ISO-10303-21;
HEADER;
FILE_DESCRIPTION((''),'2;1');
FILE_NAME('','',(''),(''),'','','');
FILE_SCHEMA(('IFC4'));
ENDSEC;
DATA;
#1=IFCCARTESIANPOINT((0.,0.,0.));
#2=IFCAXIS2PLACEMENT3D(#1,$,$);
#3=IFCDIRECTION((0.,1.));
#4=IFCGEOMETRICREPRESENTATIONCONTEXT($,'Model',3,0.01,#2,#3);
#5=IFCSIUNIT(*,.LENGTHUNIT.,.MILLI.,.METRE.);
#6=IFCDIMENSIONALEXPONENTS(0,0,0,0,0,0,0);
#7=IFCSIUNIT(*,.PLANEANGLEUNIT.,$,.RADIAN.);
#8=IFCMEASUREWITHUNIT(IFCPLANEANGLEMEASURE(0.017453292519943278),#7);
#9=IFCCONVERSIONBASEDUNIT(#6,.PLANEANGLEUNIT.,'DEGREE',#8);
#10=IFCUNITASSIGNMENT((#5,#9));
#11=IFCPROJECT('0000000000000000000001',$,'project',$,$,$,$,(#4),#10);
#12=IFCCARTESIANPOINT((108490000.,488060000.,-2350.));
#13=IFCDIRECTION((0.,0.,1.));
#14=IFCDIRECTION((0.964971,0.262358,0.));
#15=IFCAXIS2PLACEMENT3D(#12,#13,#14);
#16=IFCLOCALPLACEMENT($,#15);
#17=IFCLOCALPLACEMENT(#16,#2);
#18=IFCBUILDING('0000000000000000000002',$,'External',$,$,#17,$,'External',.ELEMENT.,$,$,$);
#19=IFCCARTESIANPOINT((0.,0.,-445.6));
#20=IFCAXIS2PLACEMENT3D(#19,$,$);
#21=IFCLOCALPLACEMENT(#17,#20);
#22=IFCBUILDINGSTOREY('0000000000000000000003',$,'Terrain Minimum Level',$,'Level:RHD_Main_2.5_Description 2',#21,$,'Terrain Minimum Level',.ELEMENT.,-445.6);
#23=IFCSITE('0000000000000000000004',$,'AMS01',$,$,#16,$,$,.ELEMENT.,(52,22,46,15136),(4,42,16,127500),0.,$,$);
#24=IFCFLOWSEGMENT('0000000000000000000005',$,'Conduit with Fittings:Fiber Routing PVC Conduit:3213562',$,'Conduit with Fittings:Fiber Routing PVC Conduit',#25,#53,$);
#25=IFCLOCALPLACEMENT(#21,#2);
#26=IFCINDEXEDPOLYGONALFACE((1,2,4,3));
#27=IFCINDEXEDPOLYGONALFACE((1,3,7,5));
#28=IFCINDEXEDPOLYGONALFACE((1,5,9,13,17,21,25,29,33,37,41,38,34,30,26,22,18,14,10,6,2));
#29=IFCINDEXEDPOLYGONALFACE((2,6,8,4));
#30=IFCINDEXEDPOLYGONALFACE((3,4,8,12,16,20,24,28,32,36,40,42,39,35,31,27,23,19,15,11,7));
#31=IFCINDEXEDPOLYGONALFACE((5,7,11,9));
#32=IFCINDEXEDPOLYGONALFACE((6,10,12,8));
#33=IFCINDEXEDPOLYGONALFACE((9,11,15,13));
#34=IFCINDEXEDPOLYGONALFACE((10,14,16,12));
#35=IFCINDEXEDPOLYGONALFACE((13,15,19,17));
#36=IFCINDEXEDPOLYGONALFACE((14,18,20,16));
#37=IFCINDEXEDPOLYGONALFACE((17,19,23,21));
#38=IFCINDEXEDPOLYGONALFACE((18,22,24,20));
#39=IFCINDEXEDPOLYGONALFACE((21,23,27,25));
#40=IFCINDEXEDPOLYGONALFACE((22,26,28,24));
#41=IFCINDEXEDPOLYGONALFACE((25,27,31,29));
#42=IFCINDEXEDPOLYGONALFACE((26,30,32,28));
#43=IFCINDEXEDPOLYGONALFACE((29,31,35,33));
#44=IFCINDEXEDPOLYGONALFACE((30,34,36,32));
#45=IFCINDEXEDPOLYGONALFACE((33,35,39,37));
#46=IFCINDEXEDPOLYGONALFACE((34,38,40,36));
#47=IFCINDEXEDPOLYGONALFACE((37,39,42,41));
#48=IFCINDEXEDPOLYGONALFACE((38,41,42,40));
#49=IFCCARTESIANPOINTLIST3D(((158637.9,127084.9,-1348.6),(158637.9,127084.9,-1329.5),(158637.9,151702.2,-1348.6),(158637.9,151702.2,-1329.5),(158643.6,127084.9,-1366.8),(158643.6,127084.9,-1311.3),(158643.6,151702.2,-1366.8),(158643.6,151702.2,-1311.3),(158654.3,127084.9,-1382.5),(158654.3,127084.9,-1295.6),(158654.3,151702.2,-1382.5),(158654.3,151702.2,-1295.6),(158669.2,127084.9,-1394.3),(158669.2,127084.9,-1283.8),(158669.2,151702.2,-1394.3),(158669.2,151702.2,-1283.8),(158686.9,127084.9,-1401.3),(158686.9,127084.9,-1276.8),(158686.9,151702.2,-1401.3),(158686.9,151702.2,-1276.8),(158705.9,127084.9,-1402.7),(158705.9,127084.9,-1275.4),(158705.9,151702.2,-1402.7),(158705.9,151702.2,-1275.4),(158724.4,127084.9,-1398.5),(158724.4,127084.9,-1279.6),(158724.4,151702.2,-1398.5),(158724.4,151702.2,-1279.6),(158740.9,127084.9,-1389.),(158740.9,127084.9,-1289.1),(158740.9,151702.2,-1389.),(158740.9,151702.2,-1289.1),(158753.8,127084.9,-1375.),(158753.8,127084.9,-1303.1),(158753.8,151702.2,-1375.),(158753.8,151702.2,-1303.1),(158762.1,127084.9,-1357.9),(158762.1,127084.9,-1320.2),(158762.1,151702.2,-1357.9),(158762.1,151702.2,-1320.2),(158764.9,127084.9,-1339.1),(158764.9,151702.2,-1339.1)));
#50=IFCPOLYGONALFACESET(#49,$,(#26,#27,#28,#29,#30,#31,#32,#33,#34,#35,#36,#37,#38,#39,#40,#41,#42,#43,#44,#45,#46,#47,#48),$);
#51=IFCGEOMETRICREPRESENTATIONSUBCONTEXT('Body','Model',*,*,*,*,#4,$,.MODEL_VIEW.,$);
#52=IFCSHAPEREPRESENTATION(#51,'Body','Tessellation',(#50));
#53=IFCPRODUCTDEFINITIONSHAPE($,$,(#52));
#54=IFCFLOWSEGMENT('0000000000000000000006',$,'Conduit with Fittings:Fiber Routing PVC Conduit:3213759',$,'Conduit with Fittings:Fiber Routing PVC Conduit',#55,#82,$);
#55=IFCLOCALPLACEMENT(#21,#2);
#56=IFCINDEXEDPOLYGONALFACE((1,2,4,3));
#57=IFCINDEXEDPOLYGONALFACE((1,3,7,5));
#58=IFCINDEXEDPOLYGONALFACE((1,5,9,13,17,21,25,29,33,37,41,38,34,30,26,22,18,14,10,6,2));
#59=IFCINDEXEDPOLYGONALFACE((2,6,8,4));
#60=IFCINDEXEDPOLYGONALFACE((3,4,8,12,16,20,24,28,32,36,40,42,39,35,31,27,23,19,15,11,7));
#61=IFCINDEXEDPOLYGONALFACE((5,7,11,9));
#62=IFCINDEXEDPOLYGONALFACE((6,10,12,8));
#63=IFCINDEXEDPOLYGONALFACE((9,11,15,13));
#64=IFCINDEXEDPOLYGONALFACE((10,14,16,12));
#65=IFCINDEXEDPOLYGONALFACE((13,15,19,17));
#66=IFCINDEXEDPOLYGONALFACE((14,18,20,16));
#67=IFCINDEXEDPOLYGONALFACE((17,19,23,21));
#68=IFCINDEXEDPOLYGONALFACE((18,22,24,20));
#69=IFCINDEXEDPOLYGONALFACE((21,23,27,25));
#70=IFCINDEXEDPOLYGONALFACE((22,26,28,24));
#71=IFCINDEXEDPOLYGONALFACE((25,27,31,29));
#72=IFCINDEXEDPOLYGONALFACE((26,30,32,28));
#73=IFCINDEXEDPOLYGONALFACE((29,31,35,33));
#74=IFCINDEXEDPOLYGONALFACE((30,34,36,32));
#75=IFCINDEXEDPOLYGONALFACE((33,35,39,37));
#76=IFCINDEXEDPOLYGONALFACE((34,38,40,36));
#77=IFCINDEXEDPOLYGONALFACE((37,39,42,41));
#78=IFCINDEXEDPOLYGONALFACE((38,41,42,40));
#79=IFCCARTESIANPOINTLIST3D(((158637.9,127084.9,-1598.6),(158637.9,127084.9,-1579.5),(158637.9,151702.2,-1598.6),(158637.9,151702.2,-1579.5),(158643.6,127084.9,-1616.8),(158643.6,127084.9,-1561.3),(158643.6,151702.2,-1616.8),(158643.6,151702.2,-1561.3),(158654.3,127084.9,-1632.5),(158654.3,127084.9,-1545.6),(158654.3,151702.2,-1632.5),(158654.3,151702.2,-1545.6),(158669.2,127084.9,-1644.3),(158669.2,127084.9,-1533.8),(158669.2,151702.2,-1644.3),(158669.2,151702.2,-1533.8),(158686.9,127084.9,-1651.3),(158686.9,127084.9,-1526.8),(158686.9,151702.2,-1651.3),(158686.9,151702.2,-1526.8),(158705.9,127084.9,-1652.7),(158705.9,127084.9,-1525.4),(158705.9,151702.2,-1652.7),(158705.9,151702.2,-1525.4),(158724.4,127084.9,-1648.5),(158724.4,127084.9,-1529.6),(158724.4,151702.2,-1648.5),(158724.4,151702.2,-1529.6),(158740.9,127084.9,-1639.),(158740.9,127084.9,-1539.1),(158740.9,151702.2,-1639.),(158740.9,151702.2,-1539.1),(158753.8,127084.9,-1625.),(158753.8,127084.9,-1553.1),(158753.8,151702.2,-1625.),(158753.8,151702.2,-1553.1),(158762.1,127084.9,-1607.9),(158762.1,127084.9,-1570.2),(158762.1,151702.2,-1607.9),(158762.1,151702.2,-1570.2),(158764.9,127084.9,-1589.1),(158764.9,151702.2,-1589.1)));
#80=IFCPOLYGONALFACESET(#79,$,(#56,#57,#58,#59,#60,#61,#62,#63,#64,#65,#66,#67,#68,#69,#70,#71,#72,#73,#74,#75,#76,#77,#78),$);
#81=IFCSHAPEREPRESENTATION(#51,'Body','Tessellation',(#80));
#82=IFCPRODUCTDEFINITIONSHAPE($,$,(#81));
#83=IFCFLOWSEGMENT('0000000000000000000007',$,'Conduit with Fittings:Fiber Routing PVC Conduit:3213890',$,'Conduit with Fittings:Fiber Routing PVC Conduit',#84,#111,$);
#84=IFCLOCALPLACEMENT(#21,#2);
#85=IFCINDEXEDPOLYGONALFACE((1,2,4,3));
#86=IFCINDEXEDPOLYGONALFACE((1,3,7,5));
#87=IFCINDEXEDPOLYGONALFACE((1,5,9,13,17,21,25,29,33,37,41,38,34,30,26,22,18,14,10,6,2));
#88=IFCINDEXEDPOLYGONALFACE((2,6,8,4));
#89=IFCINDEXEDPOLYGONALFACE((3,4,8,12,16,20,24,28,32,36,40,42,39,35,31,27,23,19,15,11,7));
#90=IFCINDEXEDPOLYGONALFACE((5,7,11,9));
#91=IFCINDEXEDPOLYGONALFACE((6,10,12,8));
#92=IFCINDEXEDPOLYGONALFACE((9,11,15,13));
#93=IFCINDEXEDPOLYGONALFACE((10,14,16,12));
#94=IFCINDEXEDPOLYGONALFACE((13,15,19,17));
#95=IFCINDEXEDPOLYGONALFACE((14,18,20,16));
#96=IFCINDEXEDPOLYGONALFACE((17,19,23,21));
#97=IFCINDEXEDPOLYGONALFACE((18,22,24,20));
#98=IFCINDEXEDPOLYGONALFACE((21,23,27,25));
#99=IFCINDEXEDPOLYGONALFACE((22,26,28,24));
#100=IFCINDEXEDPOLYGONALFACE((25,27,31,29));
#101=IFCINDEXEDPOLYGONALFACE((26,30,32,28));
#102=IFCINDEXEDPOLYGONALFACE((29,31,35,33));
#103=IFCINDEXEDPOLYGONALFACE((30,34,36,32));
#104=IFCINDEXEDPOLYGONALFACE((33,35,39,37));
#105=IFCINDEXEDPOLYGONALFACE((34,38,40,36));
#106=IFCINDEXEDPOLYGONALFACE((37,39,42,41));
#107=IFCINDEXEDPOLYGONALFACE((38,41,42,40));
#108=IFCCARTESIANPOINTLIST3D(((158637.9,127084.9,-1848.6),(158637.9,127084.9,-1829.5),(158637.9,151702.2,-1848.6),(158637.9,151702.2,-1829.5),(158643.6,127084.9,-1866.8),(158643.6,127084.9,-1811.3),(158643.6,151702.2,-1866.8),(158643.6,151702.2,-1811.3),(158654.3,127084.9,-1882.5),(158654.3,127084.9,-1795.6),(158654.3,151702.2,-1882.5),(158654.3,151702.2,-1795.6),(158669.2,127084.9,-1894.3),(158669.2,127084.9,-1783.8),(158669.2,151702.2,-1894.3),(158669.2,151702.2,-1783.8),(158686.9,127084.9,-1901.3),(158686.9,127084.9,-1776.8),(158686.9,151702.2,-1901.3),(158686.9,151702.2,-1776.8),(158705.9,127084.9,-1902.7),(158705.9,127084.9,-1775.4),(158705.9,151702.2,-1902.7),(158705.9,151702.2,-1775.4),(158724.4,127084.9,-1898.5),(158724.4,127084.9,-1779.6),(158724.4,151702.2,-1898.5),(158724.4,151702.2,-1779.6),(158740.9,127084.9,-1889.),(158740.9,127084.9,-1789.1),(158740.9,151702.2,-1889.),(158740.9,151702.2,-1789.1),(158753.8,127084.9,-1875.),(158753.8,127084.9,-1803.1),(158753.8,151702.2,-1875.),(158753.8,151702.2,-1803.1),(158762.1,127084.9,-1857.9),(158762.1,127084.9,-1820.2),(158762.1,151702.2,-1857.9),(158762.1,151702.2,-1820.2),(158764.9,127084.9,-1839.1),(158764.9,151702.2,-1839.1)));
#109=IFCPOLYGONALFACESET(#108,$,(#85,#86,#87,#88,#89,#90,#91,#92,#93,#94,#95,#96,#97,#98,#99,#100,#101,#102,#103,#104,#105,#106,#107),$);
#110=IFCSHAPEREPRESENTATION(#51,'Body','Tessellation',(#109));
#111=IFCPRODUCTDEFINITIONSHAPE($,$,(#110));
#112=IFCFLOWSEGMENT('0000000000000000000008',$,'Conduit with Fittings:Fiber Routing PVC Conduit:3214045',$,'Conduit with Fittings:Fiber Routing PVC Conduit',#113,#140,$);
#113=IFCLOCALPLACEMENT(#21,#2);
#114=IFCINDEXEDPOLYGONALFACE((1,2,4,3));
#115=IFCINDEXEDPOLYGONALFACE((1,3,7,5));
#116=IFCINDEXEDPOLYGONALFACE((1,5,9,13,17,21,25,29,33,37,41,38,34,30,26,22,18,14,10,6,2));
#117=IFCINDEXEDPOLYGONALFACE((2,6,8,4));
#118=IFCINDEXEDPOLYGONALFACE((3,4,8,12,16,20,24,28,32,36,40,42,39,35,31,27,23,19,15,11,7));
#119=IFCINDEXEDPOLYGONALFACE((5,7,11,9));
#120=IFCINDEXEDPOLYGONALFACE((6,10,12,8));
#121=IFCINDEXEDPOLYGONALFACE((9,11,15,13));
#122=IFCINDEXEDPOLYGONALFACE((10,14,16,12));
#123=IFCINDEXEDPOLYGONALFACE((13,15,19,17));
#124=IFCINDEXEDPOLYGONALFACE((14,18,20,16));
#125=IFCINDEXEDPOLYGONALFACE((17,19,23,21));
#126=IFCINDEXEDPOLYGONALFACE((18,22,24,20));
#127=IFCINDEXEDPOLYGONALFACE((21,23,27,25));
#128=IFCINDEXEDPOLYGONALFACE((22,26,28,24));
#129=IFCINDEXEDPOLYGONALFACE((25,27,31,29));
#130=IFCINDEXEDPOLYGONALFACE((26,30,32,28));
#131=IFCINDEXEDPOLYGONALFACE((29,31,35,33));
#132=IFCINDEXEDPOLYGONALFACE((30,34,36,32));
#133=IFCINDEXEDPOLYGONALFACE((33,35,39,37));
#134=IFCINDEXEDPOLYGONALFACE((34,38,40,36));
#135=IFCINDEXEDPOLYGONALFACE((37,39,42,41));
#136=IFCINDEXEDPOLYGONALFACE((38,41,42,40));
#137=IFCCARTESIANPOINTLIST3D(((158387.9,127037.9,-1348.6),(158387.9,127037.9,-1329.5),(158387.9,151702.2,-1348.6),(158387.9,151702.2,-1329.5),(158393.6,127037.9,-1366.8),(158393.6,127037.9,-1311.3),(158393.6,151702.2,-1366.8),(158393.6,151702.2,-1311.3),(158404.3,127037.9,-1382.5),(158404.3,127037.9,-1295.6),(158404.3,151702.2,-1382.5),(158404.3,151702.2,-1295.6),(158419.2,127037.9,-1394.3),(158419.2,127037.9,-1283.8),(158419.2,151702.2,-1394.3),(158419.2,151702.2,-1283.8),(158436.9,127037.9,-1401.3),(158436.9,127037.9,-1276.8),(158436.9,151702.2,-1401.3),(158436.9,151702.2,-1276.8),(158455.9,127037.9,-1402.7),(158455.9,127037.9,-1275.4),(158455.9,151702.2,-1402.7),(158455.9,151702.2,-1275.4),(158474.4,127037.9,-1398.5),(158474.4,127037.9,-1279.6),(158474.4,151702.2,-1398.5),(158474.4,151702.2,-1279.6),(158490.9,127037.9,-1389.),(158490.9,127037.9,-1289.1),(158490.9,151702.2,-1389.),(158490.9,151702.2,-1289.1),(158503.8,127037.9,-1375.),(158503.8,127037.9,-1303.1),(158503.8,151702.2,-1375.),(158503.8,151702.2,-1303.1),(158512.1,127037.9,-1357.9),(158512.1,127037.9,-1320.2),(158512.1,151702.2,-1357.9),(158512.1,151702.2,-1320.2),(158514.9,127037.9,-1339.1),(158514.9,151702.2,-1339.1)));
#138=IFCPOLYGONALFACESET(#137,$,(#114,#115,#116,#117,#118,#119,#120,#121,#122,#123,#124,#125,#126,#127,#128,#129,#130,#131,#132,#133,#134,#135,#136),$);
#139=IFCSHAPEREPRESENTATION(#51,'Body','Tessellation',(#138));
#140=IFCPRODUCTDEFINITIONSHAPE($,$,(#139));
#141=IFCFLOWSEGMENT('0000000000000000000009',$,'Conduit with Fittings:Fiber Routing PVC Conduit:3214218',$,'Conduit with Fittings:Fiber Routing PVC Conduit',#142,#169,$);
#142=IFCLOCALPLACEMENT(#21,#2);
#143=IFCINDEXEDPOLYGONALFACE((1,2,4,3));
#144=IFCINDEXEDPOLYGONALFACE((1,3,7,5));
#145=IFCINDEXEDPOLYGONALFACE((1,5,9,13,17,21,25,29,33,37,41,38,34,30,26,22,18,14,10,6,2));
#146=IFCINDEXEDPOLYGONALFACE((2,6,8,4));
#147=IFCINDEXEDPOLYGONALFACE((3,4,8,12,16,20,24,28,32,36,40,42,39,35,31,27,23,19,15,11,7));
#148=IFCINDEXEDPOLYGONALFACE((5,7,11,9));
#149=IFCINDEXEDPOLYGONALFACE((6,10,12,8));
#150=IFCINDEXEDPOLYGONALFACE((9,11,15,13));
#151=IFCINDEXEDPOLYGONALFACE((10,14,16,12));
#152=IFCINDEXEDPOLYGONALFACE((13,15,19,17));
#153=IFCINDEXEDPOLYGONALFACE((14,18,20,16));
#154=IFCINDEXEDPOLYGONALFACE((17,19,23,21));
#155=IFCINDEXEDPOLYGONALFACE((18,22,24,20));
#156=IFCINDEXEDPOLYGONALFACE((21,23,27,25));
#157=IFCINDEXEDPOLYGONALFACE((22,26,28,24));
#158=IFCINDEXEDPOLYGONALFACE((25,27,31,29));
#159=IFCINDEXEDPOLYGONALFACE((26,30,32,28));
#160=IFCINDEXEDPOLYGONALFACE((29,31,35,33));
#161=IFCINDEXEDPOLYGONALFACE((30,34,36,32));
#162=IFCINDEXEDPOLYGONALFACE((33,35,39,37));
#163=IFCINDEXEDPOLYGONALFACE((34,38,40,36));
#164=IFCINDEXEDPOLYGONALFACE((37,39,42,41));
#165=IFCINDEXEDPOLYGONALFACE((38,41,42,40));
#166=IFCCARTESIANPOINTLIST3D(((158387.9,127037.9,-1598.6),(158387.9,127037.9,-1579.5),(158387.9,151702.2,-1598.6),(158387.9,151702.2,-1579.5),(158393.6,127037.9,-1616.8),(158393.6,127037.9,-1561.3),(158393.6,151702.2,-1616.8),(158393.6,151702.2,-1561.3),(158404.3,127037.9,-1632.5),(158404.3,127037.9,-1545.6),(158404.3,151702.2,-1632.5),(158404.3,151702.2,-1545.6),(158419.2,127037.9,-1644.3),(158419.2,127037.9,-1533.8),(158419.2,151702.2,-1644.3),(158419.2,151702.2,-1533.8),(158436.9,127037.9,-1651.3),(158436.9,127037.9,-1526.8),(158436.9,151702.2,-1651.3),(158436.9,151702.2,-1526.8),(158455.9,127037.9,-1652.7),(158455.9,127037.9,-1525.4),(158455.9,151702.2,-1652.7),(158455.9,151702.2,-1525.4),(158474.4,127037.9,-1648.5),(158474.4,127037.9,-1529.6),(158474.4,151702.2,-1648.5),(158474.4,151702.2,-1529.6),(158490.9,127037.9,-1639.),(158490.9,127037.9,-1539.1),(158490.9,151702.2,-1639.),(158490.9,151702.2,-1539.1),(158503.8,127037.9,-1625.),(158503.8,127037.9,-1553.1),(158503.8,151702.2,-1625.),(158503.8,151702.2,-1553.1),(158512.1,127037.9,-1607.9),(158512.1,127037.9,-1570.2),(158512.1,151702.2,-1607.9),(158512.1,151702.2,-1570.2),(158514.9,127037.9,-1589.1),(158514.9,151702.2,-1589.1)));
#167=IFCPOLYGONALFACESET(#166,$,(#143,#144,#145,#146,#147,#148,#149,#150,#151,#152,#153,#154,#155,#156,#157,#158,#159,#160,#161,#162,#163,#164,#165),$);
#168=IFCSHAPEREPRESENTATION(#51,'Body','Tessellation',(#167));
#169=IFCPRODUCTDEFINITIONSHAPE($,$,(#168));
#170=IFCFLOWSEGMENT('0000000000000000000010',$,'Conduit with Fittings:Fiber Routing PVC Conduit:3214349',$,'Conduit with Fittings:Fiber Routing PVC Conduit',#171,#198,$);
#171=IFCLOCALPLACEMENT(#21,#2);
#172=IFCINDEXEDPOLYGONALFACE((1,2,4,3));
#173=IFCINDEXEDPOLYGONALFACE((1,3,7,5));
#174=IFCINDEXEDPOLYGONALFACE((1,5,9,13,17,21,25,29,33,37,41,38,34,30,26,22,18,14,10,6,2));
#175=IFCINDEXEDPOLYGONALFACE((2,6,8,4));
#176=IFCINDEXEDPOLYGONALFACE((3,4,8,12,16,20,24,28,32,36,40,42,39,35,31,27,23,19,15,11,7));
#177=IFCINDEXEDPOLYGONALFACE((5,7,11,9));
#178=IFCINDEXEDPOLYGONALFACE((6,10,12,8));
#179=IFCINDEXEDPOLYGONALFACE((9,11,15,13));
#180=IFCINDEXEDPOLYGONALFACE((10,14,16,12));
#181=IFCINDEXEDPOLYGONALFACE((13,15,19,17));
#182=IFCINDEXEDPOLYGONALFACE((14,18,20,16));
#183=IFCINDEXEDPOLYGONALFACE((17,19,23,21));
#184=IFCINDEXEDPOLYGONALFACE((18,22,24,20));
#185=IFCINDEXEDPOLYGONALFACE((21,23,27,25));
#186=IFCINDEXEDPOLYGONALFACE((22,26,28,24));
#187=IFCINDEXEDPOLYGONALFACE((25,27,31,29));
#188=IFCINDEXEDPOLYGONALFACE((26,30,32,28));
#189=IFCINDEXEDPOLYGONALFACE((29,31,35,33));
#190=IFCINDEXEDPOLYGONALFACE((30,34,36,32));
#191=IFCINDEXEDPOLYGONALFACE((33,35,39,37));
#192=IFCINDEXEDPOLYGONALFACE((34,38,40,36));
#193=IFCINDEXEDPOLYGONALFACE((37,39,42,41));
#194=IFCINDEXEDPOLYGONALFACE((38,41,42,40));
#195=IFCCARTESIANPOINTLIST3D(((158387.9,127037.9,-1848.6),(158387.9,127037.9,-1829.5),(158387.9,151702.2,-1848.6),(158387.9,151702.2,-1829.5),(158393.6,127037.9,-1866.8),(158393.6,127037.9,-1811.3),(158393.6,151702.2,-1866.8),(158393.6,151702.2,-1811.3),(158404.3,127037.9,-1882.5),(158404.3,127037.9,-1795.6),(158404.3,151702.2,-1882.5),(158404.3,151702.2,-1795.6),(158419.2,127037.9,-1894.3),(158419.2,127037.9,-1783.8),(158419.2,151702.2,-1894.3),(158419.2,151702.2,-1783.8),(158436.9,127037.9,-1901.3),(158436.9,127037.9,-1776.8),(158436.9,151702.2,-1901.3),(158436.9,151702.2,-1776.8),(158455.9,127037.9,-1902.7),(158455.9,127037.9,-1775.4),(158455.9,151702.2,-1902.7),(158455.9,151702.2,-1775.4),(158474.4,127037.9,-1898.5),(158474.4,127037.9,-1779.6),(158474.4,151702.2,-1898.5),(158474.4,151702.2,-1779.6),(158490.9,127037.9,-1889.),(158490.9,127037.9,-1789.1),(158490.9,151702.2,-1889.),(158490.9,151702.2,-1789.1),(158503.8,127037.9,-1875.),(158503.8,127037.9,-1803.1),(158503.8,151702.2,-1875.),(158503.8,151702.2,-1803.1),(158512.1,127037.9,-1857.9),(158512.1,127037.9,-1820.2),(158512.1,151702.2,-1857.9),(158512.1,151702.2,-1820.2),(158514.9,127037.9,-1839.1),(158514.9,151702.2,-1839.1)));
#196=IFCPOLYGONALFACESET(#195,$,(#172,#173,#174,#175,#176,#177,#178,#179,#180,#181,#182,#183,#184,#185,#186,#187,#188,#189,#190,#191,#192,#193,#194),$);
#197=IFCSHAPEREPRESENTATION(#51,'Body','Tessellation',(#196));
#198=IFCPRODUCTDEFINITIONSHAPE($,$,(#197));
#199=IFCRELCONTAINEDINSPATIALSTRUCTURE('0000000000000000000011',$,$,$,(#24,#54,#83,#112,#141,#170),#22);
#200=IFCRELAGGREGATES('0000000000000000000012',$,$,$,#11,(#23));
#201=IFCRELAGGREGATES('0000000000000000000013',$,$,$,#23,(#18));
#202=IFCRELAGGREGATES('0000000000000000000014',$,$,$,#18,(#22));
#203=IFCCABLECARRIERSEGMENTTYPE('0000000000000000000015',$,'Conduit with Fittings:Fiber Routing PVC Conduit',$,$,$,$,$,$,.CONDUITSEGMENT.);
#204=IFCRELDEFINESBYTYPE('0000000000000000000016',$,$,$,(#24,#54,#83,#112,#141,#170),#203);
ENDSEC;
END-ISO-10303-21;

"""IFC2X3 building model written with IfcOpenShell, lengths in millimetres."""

from ifc_helpers import new_model, entity, si_unit, converted_unit, direction, frame, origin, origin_2d_with_axis, place, context, subcontext, project, spatial, circle, extrude, type_object, element, save


model = new_model("IFC2X3")

# Units and contexts
model_context = context("Model", 3, precision=0.01, world=origin(), true_north=direction((0.0, 1.0)))
body_context = subcontext(model_context, "Body", "Model", "MODEL_VIEW")
ifc_project = project(units=[si_unit("LENGTHUNIT", "METRE", prefix="MILLI"), converted_unit("PLANEANGLEUNIT", "DEGREE", entity("IfcPlaneAngleMeasure", 0.017453292519943278), si_unit("PLANEANGLEUNIT", "RADIAN"), dimensions=[0, 0, 0, 0, 0, 0, 0])], contexts=[model_context])

# Site, building, storey
site_placement = place(None, frame((108490000.0, 488060000.0, -2350.0), z_axis=(0.0, 0.0, 1.0), x_axis=(0.964971, 0.262358, 0.0)))
site = spatial("IfcSite", under=ifc_project, at=site_placement, Name="AMS01", CompositionType="ELEMENT", RefLatitude=(52, 22, 46, 15136), RefLongitude=(4, 42, 16, 127500), RefElevation=0.0)
building_placement = place(site_placement, origin())
building = spatial("IfcBuilding", under=site, at=building_placement, Name="External", LongName="External", CompositionType="ELEMENT")
storey_placement = place(building_placement, frame((0.0, 0.0, -445.6)))
storey = spatial("IfcBuildingStorey", under=building, at=storey_placement, Name="Terrain Minimum Level", ObjectType="Level:RHD_Main_2.5_Description 2", LongName="Terrain Minimum Level", CompositionType="ELEMENT", Elevation=-445.6)

# Flow segments
cable_carrier_segment_type = type_object("IfcCableCarrierSegmentType", Name="Conduit with Fittings:Fiber Routing PVC Conduit", PredefinedType="CONDUITSEGMENT")
flow_segment_1_placement = place(storey_placement, origin())
element("IfcFlowSegment", 1, at=flow_segment_1_placement, inside=storey, type_object=cable_carrier_segment_type, Name="Conduit with Fittings:Fiber Routing PVC Conduit:3213562", ObjectType="Conduit with Fittings:Fiber Routing PVC Conduit", context=body_context, shape_type="SweptSolid", body=[
    extrude(circle(Radius=63.9, at=origin_2d_with_axis()), frame((158701.1, 127084.9, -1339.1), z_axis=(0.0, 1.0, 0.0), x_axis=(1.0, 0.0, 0.0)), (0.0, 0.0, 1.0), 24617.4),
])
flow_segment_2_placement = place(storey_placement, origin())
element("IfcFlowSegment", 2, at=flow_segment_2_placement, inside=storey, type_object=cable_carrier_segment_type, Name="Conduit with Fittings:Fiber Routing PVC Conduit:3213759", ObjectType="Conduit with Fittings:Fiber Routing PVC Conduit", context=body_context, shape_type="SweptSolid", body=[
    extrude(circle(Radius=63.9, at=origin_2d_with_axis()), frame((158701.1, 127084.9, -1589.1), z_axis=(0.0, 1.0, 0.0), x_axis=(1.0, 0.0, 0.0)), (0.0, 0.0, 1.0), 24617.4),
])
flow_segment_3_placement = place(storey_placement, origin())
element("IfcFlowSegment", 3, at=flow_segment_3_placement, inside=storey, type_object=cable_carrier_segment_type, Name="Conduit with Fittings:Fiber Routing PVC Conduit:3213890", ObjectType="Conduit with Fittings:Fiber Routing PVC Conduit", context=body_context, shape_type="SweptSolid", body=[
    extrude(circle(Radius=63.9, at=origin_2d_with_axis()), frame((158701.1, 127084.9, -1839.1), z_axis=(0.0, 1.0, 0.0), x_axis=(1.0, 0.0, 0.0)), (0.0, 0.0, 1.0), 24617.4),
])
flow_segment_4_placement = place(storey_placement, origin())
element("IfcFlowSegment", 4, at=flow_segment_4_placement, inside=storey, type_object=cable_carrier_segment_type, Name="Conduit with Fittings:Fiber Routing PVC Conduit:3214045", ObjectType="Conduit with Fittings:Fiber Routing PVC Conduit", context=body_context, shape_type="SweptSolid", body=[
    extrude(circle(Radius=63.9, at=origin_2d_with_axis()), frame((158451.1, 127037.9, -1339.1), z_axis=(0.0, 1.0, 0.0), x_axis=(1.0, 0.0, 0.0)), (0.0, 0.0, 1.0), 24664.4),
])
flow_segment_5_placement = place(storey_placement, origin())
element("IfcFlowSegment", 5, at=flow_segment_5_placement, inside=storey, type_object=cable_carrier_segment_type, Name="Conduit with Fittings:Fiber Routing PVC Conduit:3214218", ObjectType="Conduit with Fittings:Fiber Routing PVC Conduit", context=body_context, shape_type="SweptSolid", body=[
    extrude(circle(Radius=63.9, at=origin_2d_with_axis()), frame((158451.1, 127037.9, -1589.1), z_axis=(0.0, 1.0, 0.0), x_axis=(1.0, 0.0, 0.0)), (0.0, 0.0, 1.0), 24664.4),
])
flow_segment_6_placement = place(storey_placement, origin())
element("IfcFlowSegment", 6, at=flow_segment_6_placement, inside=storey, type_object=cable_carrier_segment_type, Name="Conduit with Fittings:Fiber Routing PVC Conduit:3214349", ObjectType="Conduit with Fittings:Fiber Routing PVC Conduit", context=body_context, shape_type="SweptSolid", body=[
    extrude(circle(Radius=63.9, at=origin_2d_with_axis()), frame((158451.1, 127037.9, -1839.1), z_axis=(0.0, 1.0, 0.0), x_axis=(1.0, 0.0, 0.0)), (0.0, 0.0, 1.0), 24664.4),
])

save(model, "model.ifc")
